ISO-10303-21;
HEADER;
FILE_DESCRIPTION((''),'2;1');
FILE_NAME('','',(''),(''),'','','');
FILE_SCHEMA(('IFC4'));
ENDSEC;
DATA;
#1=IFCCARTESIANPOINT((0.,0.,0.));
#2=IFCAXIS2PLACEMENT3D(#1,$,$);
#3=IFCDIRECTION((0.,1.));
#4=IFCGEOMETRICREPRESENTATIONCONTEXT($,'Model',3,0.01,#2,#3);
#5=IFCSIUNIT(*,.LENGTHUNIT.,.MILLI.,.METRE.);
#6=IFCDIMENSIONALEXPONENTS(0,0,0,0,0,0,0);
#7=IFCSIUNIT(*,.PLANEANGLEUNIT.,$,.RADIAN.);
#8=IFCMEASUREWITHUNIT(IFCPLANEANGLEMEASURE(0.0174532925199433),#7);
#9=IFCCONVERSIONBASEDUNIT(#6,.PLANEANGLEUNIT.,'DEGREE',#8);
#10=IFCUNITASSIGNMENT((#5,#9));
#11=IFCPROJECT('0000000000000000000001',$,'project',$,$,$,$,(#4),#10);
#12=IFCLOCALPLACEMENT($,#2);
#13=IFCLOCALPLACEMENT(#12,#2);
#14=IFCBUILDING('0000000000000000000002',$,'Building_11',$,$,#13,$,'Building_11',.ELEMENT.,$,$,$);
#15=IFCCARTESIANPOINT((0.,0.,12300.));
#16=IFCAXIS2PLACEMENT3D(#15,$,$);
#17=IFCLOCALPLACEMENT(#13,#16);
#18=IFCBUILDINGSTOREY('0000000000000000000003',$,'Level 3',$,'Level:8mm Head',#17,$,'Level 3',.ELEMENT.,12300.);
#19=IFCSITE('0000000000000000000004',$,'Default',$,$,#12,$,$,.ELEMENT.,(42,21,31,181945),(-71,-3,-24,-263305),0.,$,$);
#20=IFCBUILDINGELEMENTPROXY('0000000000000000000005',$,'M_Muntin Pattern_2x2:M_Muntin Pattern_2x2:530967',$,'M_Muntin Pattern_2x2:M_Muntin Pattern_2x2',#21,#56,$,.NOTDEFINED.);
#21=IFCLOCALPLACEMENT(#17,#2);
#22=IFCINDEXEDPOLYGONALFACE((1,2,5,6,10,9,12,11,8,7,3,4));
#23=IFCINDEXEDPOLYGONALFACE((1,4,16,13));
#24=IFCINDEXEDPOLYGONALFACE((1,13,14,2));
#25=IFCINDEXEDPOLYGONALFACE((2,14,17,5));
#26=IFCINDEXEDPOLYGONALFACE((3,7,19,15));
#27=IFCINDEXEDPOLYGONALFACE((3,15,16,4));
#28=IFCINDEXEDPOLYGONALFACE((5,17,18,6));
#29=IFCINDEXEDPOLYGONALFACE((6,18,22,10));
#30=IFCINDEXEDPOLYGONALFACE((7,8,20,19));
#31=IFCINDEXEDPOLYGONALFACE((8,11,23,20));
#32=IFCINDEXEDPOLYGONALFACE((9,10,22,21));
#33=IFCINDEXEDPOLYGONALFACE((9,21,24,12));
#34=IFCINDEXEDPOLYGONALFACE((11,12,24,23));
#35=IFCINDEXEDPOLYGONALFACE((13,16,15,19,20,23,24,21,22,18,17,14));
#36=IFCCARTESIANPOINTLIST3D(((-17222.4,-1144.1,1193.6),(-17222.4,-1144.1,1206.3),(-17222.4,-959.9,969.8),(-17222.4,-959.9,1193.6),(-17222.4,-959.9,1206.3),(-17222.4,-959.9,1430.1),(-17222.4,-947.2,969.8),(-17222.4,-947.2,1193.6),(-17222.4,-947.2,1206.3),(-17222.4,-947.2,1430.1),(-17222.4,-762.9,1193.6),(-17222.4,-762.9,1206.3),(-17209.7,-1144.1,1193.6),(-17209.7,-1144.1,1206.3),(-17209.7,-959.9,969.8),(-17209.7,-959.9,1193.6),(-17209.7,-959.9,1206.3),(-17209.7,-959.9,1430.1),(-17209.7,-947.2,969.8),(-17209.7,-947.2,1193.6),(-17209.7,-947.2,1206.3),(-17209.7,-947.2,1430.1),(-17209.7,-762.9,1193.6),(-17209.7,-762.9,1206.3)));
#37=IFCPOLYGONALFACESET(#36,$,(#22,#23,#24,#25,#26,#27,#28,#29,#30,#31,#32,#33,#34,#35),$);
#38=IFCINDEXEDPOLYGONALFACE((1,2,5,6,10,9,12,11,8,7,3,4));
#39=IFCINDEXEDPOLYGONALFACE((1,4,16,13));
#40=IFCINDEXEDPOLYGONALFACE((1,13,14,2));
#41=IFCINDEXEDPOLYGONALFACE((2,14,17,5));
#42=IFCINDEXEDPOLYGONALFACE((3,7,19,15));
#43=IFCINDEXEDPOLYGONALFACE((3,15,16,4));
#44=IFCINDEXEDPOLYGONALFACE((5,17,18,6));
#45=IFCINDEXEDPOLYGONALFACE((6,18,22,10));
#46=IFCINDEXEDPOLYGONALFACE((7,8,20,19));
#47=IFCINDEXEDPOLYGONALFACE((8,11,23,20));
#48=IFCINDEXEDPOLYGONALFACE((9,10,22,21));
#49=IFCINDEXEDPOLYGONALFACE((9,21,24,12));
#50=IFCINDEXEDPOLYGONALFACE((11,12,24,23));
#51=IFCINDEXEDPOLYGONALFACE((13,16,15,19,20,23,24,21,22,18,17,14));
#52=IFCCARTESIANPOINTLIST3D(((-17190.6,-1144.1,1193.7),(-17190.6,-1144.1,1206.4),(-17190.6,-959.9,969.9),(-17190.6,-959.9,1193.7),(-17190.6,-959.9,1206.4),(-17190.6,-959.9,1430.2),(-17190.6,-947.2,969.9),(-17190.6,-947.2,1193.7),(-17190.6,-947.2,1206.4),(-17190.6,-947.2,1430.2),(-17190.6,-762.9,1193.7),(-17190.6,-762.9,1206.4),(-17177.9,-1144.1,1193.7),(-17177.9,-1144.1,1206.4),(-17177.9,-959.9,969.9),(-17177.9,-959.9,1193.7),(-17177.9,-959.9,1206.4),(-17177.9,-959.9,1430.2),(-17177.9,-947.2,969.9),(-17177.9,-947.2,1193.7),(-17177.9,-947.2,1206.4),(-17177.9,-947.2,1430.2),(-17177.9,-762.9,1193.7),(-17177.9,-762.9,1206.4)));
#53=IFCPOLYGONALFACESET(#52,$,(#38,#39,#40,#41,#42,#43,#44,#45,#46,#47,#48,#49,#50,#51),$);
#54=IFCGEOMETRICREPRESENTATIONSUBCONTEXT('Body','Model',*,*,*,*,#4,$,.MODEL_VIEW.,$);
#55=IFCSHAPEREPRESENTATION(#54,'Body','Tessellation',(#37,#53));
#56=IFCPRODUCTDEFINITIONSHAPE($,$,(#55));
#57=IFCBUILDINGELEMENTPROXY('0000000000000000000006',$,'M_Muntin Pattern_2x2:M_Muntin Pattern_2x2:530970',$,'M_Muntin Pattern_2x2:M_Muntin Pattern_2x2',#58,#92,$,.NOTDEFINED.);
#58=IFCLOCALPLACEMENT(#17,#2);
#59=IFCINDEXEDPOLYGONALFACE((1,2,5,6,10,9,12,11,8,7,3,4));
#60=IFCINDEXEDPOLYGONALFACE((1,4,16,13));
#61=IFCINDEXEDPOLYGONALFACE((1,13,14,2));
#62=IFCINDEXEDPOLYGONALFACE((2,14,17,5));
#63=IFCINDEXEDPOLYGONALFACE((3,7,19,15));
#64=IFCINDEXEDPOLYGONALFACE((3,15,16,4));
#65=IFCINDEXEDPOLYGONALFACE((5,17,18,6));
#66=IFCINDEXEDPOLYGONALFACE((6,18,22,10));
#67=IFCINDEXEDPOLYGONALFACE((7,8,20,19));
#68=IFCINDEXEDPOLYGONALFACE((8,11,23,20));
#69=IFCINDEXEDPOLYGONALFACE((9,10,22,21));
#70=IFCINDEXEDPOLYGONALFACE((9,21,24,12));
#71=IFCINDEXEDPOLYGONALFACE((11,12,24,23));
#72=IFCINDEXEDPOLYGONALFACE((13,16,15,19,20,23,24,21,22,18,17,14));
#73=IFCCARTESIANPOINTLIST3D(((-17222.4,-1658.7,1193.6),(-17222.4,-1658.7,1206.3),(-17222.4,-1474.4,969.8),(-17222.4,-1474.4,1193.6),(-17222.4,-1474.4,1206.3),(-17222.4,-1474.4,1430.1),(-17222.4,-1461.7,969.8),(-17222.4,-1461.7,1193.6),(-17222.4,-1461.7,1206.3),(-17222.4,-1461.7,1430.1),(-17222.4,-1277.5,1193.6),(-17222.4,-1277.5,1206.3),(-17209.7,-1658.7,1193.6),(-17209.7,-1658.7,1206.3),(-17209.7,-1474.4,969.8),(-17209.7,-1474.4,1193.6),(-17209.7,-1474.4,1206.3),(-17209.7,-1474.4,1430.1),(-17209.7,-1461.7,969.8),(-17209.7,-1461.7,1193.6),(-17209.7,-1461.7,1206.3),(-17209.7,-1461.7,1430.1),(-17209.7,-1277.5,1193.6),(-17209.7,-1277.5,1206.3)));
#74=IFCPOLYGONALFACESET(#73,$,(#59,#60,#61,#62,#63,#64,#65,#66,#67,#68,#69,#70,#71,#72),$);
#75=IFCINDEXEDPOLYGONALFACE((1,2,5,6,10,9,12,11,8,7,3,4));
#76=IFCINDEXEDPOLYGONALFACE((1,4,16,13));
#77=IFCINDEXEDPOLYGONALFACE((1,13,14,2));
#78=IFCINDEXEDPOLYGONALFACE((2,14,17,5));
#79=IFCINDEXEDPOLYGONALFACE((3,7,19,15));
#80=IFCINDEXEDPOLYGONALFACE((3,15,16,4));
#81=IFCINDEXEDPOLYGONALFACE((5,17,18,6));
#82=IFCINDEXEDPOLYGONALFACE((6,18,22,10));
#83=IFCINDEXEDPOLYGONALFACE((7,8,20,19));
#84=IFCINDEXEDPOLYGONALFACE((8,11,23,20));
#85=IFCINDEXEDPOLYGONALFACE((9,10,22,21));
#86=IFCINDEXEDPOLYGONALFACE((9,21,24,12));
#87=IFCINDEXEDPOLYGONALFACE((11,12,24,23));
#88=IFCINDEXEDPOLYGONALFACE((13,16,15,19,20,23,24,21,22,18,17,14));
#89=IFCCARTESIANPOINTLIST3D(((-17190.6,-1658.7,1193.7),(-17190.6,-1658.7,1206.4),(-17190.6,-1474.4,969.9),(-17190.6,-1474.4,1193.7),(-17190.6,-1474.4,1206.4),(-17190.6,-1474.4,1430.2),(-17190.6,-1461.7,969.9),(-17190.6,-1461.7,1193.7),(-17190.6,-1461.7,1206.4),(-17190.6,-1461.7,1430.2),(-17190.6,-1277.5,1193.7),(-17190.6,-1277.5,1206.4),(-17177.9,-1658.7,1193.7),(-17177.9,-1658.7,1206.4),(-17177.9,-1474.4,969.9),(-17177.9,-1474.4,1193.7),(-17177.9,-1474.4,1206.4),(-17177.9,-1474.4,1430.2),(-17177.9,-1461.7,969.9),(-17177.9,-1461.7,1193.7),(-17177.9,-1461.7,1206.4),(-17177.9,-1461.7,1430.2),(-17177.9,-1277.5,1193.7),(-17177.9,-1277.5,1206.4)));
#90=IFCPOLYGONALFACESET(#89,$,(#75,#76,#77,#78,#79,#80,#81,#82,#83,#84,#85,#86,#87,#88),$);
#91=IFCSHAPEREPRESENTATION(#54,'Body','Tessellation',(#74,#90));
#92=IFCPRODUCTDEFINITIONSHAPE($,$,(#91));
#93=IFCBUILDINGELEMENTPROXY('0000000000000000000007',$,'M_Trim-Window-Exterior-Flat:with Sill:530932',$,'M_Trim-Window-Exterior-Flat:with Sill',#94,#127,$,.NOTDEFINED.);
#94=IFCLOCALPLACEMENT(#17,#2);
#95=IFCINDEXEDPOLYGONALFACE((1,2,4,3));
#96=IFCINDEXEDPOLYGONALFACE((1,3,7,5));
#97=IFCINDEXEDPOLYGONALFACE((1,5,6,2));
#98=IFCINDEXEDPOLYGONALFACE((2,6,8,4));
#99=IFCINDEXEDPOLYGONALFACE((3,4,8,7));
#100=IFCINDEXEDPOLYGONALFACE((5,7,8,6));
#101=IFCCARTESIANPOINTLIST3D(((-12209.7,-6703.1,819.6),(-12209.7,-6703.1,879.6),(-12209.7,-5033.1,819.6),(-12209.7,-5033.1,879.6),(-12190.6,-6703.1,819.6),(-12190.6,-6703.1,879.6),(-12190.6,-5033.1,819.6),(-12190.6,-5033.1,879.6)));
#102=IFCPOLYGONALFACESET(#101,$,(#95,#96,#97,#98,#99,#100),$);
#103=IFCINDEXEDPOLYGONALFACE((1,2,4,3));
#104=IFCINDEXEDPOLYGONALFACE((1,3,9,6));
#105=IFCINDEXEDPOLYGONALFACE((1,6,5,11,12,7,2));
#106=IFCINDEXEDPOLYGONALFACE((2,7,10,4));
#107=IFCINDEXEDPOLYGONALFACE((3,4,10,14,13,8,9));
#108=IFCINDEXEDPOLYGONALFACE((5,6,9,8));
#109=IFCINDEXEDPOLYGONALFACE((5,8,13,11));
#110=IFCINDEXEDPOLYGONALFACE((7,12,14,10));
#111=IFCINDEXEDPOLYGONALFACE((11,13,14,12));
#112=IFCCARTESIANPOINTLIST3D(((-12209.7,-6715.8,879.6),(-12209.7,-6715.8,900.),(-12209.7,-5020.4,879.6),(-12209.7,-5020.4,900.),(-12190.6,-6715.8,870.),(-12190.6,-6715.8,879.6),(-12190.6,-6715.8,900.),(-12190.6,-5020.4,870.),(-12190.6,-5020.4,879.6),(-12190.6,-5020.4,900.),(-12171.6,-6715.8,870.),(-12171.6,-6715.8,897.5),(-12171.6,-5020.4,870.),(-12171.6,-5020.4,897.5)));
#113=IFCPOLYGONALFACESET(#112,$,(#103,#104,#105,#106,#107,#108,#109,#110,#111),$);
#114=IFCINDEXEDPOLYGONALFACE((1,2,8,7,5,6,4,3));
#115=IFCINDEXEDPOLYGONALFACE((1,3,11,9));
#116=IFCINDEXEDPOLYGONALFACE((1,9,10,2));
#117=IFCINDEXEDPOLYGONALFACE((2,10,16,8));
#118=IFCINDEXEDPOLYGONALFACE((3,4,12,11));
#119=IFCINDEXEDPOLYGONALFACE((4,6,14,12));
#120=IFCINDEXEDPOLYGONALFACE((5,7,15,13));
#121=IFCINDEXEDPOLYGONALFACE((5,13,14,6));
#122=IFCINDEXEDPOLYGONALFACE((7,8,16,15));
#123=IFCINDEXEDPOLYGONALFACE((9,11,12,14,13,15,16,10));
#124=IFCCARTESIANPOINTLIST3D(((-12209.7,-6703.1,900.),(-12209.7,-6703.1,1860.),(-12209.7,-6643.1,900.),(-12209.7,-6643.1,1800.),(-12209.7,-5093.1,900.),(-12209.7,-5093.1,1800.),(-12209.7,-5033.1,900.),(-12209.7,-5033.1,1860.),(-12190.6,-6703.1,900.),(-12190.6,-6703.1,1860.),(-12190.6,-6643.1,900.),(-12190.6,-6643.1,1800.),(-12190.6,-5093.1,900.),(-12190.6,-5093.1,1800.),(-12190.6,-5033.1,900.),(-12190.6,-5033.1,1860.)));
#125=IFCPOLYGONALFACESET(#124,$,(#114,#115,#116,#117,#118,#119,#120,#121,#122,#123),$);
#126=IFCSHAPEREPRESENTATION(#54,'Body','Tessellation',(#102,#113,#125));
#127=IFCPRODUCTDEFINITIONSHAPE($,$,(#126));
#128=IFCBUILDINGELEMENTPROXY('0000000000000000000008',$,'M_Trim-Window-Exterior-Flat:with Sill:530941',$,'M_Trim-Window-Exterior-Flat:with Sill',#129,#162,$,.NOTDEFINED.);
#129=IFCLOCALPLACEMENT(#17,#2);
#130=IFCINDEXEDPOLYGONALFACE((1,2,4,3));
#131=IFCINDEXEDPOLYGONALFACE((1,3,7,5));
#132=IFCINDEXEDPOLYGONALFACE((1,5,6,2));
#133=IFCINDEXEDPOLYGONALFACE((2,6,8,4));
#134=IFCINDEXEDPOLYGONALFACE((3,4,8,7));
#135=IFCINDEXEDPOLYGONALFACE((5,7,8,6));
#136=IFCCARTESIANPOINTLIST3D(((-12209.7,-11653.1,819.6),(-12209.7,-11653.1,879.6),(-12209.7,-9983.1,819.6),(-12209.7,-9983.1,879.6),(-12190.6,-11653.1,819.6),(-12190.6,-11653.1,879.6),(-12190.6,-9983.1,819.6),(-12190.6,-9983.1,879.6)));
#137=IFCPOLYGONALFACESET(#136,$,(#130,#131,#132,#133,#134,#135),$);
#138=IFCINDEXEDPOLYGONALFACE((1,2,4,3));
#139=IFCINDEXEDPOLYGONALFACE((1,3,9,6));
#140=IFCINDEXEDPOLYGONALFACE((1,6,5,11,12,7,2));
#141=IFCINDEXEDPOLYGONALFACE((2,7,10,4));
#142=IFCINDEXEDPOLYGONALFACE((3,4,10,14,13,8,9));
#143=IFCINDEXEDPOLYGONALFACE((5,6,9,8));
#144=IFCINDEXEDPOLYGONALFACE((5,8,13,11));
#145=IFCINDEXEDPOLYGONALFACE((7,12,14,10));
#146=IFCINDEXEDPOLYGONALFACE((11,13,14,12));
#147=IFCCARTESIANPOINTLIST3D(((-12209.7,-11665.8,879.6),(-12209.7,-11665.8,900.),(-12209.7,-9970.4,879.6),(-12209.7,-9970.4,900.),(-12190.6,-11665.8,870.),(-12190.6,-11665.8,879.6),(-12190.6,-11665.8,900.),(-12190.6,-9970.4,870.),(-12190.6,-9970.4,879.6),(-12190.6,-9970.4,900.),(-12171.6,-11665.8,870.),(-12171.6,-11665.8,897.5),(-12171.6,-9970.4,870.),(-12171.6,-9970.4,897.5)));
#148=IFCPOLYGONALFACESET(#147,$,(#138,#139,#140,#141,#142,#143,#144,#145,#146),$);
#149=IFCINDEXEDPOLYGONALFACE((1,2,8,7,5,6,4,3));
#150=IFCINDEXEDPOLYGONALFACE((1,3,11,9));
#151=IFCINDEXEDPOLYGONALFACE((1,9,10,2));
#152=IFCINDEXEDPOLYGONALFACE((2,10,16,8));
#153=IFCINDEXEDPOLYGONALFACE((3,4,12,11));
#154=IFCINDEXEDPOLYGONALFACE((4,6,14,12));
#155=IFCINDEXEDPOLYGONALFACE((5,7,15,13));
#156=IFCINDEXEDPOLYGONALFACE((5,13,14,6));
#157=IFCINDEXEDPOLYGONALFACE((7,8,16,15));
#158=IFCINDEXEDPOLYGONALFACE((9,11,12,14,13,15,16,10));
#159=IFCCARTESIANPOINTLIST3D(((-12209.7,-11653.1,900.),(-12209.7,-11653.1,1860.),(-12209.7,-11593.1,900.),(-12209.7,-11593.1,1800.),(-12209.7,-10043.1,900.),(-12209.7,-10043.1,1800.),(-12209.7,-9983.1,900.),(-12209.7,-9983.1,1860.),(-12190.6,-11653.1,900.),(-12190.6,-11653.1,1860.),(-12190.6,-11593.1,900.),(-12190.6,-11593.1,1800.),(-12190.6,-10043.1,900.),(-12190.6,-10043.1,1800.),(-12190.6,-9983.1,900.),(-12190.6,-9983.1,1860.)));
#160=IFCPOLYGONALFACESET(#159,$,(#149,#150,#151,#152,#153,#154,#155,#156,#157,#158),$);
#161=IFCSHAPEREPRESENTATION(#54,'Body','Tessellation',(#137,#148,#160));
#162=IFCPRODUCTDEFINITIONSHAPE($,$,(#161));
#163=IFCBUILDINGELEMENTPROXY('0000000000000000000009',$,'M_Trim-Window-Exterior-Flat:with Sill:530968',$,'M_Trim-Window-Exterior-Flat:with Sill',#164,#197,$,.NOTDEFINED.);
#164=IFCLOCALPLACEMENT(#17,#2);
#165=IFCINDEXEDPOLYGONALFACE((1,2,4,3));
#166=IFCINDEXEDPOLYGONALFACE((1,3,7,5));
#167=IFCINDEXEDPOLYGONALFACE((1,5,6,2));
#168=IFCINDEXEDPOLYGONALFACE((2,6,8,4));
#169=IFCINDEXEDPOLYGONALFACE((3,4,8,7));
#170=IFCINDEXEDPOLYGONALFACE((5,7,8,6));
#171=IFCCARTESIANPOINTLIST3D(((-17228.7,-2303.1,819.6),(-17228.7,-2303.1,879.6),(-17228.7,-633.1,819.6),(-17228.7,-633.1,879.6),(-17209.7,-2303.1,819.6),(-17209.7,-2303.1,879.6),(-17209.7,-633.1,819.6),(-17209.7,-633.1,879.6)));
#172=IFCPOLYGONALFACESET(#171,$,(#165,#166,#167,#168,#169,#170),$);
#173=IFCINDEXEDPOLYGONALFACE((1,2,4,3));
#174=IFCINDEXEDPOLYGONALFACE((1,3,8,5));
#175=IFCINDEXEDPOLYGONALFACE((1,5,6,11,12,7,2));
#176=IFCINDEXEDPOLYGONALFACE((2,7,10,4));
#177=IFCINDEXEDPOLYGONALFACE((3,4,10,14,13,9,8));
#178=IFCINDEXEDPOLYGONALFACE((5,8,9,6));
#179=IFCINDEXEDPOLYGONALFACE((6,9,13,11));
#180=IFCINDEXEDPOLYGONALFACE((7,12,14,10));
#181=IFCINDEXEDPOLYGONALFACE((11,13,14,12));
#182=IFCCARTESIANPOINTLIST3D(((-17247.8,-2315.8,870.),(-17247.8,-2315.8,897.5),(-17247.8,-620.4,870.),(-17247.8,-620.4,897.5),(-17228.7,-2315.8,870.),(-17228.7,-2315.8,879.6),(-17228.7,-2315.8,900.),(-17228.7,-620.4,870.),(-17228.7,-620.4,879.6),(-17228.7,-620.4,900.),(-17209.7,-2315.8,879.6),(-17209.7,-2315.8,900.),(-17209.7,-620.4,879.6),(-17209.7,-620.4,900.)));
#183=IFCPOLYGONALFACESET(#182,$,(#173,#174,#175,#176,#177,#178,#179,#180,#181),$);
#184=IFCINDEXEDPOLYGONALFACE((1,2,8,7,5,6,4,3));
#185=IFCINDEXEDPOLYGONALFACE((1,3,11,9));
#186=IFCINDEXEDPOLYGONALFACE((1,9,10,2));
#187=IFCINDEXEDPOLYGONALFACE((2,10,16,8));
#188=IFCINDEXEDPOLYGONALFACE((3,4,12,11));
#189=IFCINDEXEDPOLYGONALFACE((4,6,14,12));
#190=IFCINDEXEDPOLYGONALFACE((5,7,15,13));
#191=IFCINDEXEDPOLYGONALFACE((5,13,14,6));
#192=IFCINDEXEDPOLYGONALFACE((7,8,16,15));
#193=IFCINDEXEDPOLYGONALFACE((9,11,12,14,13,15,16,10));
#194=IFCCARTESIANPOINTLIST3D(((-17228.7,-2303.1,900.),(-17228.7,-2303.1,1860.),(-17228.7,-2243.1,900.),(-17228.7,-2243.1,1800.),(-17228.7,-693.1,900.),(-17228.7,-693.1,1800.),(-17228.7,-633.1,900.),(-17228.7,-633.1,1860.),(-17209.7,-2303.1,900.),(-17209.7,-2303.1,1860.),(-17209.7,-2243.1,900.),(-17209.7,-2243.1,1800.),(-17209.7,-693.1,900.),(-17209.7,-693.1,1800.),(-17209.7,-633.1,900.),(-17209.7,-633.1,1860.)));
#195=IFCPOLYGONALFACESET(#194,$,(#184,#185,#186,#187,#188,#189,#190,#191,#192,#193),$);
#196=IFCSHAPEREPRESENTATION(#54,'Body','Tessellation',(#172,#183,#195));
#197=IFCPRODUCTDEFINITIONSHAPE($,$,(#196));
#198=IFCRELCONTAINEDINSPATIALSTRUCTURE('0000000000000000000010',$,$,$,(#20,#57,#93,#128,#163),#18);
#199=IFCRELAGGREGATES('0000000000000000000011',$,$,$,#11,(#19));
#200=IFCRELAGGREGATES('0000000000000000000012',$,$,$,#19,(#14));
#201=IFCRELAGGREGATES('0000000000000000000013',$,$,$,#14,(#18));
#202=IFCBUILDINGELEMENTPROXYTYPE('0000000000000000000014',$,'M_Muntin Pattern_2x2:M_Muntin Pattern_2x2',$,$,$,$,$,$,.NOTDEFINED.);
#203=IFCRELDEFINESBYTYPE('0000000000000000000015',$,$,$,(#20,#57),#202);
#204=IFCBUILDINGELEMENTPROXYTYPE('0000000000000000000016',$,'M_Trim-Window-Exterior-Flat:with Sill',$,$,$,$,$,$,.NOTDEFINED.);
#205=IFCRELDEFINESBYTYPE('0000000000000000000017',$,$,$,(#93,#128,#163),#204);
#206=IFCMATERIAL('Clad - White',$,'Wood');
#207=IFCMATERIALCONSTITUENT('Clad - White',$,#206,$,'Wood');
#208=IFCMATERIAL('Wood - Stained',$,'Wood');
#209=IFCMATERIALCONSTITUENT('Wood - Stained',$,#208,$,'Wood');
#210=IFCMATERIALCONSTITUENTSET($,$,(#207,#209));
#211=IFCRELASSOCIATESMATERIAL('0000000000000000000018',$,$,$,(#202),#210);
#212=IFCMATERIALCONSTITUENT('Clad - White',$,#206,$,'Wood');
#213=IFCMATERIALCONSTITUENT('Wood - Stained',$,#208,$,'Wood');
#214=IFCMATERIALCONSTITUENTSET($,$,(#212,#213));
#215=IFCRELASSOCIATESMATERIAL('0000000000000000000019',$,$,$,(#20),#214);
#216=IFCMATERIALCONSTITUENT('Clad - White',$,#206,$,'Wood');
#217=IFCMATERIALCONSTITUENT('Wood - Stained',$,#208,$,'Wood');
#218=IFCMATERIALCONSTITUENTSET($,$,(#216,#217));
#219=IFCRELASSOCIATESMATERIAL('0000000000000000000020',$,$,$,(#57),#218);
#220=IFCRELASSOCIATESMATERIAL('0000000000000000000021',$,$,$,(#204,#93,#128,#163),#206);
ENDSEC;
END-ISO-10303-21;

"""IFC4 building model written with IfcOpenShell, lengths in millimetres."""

from ifc_helpers import new_model, entity, si_unit, converted_unit, direction, frame, origin, place, context, subcontext, project, spatial, indexed_curve, outline, extrude, source, transform, mapped, material, constituent, constituent_set, type_object, type_shapes, element, save


model = new_model("IFC4")

# Units and contexts
model_context = context("Model", 3, precision=0.01, world=origin(), true_north=direction((0.0, 1.0)))
body_context = subcontext(model_context, "Body", "Model", "MODEL_VIEW")
ifc_project = project(units=[si_unit("LENGTHUNIT", "METRE", prefix="MILLI"), converted_unit("PLANEANGLEUNIT", "DEGREE", entity("IfcPlaneAngleMeasure", 0.0174532925199433), si_unit("PLANEANGLEUNIT", "RADIAN"), dimensions=[0, 0, 0, 0, 0, 0, 0])], contexts=[model_context])

# Site, building, storey
site_placement = place(None, origin())
site = spatial("IfcSite", under=ifc_project, at=site_placement, Name="Default", CompositionType="ELEMENT", RefLatitude=(42, 21, 31, 181945), RefLongitude=(-71, -3, -24, -263305), RefElevation=0.0)
building_placement = place(site_placement, origin())
building = spatial("IfcBuilding", under=site, at=building_placement, Name="Building_11", LongName="Building_11", CompositionType="ELEMENT")
storey_placement = place(building_placement, frame((0.0, 0.0, 12300.0)))
storey = spatial("IfcBuildingStorey", under=building, at=storey_placement, Name="Level 3", ObjectType="Level:8mm Head", LongName="Level 3", CompositionType="ELEMENT", Elevation=12300.0)

# Building element proxies
ifc_material_1 = material(Name="Clad - White", Category="Wood")
ifc_material_2 = material(Name="Wood - Stained", Category="Wood")
ifc_constituent_1 = constituent(ifc_material_1, Name="Clad - White", Category="Wood")
ifc_constituent_2 = constituent(ifc_material_2, Name="Wood - Stained", Category="Wood")
ifc_constituent_set_1 = constituent_set(constituents=[ifc_constituent_1, ifc_constituent_2])
building_element_proxy_type_1 = type_object("IfcBuildingElementProxyType", Name="M_Muntin Pattern_2x2:M_Muntin Pattern_2x2", PredefinedType="NOTDEFINED", material=ifc_constituent_set_1)
shared_shape_1 = source(origin(), body_context, "Body", "SweptSolid", [
    extrude(outline(indexed_curve([(6.4, -6.4), (230.1, -6.4), (230.1, 6.3), (6.4, 6.3), (6.4, 190.6), (-6.3, 190.6), (-6.3, 6.3), (-230.2, 6.3), (-230.2, -6.4), (-6.3, -6.4), (-6.3, -190.6), (6.4, -190.6), (6.4, -6.4)], self_intersect=False)), frame((0.0, -22.2, 230.1), z_axis=(0.0, 1.0, 0.0), x_axis=(0.0, 0.0, 1.0)), (0.0, 0.0, 1.0), 12.7),
    extrude(outline(indexed_curve([(6.4, -6.4), (230.2, -6.4), (230.2, 6.3), (6.4, 6.3), (6.4, 190.6), (-6.3, 190.6), (-6.3, 6.3), (-230.2, 6.3), (-230.2, -6.4), (-6.3, -6.4), (-6.3, -190.6), (6.4, -190.6), (6.4, -6.4)], self_intersect=False)), frame((0.0, 9.5, 230.2), z_axis=(0.0, 1.0, 0.0), x_axis=(0.0, 0.0, 1.0)), (0.0, 0.0, 1.0), 12.7),
])
type_shapes(building_element_proxy_type_1, [shared_shape_1])
ifc_constituent_3 = constituent(ifc_material_1, Name="Clad - White", Category="Wood")
ifc_constituent_4 = constituent(ifc_material_2, Name="Wood - Stained", Category="Wood")
ifc_constituent_set_2 = constituent_set(constituents=[ifc_constituent_3, ifc_constituent_4])
proxy_1_placement = place(storey_placement, frame((-17200.2, -953.5, 969.9), z_axis=(0.0, 0.0, 1.0), x_axis=(0.0, -1.0, 0.0)))
element("IfcBuildingElementProxy", 1, at=proxy_1_placement, inside=storey, type_object=building_element_proxy_type_1, material=ifc_constituent_set_2, Name="M_Muntin Pattern_2x2:M_Muntin Pattern_2x2:530967", ObjectType="M_Muntin Pattern_2x2:M_Muntin Pattern_2x2", PredefinedType="NOTDEFINED", context=body_context, shape_type="MappedRepresentation", body=[
    mapped(shared_shape_1, transform((0.0, 0.0, 0.0), scale=1.0)),
])
ifc_constituent_5 = constituent(ifc_material_1, Name="Clad - White", Category="Wood")
ifc_constituent_6 = constituent(ifc_material_2, Name="Wood - Stained", Category="Wood")
ifc_constituent_set_3 = constituent_set(constituents=[ifc_constituent_5, ifc_constituent_6])
proxy_2_placement = place(storey_placement, frame((-17200.2, -1468.1, 969.9), z_axis=(0.0, 0.0, 1.0), x_axis=(0.0, -1.0, 0.0)))
element("IfcBuildingElementProxy", 2, at=proxy_2_placement, inside=storey, type_object=building_element_proxy_type_1, material=ifc_constituent_set_3, Name="M_Muntin Pattern_2x2:M_Muntin Pattern_2x2:530970", ObjectType="M_Muntin Pattern_2x2:M_Muntin Pattern_2x2", PredefinedType="NOTDEFINED", context=body_context, shape_type="MappedRepresentation", body=[
    mapped(shared_shape_1, transform((0.0, 0.0, 0.0), scale=1.0)),
])
building_element_proxy_type_2 = type_object("IfcBuildingElementProxyType", Name="M_Trim-Window-Exterior-Flat:with Sill", PredefinedType="NOTDEFINED", material=ifc_material_1)
shared_shape_2 = source(origin(), body_context, "Body", "SweptSolid", [
    extrude(outline(indexed_curve([(-835.0, -30.0), (835.0, -30.0), (835.0, 30.0), (-835.0, 30.0), (-835.0, -30.0)], self_intersect=False)), frame((0.0, -950.4, 0.0), z_axis=(0.0, 0.0, 1.0), x_axis=(-1.0, 0.0, 0.0)), (0.0, 0.0, 1.0), 19.1),
    extrude(outline(indexed_curve([(-19.0, -15.2), (0.0, -15.2), (0.0, -5.7), (19.0, -5.7), (19.0, 14.8), (0.0, 14.8), (-19.0, 12.3), (-19.0, -15.2)], self_intersect=False)), frame((-847.7, -914.8, 19.0), z_axis=(1.0, 0.0, 0.0), x_axis=(0.0, 0.0, -1.0)), (0.0, 0.0, 1.0), 1695.4),
    extrude(outline(indexed_curve([(-495.0, -835.0), (465.0, -835.0), (465.0, -775.0), (-435.0, -775.0), (-435.0, 775.0), (465.0, 775.0), (465.0, 835.0), (-495.0, 835.0), (-495.0, -835.0)], self_intersect=False)), frame((0.0, -435.0, 0.0), z_axis=(0.0, 0.0, 1.0), x_axis=(0.0, -1.0, 0.0)), (0.0, 0.0, 1.0), 19.1),
])
type_shapes(building_element_proxy_type_2, [shared_shape_2])
for number, where, z_axis, x_axis, name in (
    (3, (-12209.7, -5868.1, 1800.0), (1.0, 0.0, 0.0), (0.0, 1.0, 0.0), "M_Trim-Window-Exterior-Flat:with Sill:530932"),
    (4, (-12209.7, -10818.1, 1800.0), (1.0, 0.0, 0.0), (0.0, 1.0, 0.0), "M_Trim-Window-Exterior-Flat:with Sill:530941"),
    (5, (-17209.7, -1468.1, 1800.0), (-1.0, 0.0, 0.0), (0.0, -1.0, 0.0), "M_Trim-Window-Exterior-Flat:with Sill:530968"),
):
    element("IfcBuildingElementProxy", number, at=place(storey_placement, frame(where, z_axis=z_axis, x_axis=x_axis)), inside=storey, type_object=building_element_proxy_type_2, material=ifc_material_1, Name=name, ObjectType="M_Trim-Window-Exterior-Flat:with Sill", PredefinedType="NOTDEFINED", context=body_context, shape_type="MappedRepresentation", body=[
        mapped(shared_shape_2, transform((0.0, 0.0, 0.0), scale=1.0)),
    ])

save(model, "model.ifc")
